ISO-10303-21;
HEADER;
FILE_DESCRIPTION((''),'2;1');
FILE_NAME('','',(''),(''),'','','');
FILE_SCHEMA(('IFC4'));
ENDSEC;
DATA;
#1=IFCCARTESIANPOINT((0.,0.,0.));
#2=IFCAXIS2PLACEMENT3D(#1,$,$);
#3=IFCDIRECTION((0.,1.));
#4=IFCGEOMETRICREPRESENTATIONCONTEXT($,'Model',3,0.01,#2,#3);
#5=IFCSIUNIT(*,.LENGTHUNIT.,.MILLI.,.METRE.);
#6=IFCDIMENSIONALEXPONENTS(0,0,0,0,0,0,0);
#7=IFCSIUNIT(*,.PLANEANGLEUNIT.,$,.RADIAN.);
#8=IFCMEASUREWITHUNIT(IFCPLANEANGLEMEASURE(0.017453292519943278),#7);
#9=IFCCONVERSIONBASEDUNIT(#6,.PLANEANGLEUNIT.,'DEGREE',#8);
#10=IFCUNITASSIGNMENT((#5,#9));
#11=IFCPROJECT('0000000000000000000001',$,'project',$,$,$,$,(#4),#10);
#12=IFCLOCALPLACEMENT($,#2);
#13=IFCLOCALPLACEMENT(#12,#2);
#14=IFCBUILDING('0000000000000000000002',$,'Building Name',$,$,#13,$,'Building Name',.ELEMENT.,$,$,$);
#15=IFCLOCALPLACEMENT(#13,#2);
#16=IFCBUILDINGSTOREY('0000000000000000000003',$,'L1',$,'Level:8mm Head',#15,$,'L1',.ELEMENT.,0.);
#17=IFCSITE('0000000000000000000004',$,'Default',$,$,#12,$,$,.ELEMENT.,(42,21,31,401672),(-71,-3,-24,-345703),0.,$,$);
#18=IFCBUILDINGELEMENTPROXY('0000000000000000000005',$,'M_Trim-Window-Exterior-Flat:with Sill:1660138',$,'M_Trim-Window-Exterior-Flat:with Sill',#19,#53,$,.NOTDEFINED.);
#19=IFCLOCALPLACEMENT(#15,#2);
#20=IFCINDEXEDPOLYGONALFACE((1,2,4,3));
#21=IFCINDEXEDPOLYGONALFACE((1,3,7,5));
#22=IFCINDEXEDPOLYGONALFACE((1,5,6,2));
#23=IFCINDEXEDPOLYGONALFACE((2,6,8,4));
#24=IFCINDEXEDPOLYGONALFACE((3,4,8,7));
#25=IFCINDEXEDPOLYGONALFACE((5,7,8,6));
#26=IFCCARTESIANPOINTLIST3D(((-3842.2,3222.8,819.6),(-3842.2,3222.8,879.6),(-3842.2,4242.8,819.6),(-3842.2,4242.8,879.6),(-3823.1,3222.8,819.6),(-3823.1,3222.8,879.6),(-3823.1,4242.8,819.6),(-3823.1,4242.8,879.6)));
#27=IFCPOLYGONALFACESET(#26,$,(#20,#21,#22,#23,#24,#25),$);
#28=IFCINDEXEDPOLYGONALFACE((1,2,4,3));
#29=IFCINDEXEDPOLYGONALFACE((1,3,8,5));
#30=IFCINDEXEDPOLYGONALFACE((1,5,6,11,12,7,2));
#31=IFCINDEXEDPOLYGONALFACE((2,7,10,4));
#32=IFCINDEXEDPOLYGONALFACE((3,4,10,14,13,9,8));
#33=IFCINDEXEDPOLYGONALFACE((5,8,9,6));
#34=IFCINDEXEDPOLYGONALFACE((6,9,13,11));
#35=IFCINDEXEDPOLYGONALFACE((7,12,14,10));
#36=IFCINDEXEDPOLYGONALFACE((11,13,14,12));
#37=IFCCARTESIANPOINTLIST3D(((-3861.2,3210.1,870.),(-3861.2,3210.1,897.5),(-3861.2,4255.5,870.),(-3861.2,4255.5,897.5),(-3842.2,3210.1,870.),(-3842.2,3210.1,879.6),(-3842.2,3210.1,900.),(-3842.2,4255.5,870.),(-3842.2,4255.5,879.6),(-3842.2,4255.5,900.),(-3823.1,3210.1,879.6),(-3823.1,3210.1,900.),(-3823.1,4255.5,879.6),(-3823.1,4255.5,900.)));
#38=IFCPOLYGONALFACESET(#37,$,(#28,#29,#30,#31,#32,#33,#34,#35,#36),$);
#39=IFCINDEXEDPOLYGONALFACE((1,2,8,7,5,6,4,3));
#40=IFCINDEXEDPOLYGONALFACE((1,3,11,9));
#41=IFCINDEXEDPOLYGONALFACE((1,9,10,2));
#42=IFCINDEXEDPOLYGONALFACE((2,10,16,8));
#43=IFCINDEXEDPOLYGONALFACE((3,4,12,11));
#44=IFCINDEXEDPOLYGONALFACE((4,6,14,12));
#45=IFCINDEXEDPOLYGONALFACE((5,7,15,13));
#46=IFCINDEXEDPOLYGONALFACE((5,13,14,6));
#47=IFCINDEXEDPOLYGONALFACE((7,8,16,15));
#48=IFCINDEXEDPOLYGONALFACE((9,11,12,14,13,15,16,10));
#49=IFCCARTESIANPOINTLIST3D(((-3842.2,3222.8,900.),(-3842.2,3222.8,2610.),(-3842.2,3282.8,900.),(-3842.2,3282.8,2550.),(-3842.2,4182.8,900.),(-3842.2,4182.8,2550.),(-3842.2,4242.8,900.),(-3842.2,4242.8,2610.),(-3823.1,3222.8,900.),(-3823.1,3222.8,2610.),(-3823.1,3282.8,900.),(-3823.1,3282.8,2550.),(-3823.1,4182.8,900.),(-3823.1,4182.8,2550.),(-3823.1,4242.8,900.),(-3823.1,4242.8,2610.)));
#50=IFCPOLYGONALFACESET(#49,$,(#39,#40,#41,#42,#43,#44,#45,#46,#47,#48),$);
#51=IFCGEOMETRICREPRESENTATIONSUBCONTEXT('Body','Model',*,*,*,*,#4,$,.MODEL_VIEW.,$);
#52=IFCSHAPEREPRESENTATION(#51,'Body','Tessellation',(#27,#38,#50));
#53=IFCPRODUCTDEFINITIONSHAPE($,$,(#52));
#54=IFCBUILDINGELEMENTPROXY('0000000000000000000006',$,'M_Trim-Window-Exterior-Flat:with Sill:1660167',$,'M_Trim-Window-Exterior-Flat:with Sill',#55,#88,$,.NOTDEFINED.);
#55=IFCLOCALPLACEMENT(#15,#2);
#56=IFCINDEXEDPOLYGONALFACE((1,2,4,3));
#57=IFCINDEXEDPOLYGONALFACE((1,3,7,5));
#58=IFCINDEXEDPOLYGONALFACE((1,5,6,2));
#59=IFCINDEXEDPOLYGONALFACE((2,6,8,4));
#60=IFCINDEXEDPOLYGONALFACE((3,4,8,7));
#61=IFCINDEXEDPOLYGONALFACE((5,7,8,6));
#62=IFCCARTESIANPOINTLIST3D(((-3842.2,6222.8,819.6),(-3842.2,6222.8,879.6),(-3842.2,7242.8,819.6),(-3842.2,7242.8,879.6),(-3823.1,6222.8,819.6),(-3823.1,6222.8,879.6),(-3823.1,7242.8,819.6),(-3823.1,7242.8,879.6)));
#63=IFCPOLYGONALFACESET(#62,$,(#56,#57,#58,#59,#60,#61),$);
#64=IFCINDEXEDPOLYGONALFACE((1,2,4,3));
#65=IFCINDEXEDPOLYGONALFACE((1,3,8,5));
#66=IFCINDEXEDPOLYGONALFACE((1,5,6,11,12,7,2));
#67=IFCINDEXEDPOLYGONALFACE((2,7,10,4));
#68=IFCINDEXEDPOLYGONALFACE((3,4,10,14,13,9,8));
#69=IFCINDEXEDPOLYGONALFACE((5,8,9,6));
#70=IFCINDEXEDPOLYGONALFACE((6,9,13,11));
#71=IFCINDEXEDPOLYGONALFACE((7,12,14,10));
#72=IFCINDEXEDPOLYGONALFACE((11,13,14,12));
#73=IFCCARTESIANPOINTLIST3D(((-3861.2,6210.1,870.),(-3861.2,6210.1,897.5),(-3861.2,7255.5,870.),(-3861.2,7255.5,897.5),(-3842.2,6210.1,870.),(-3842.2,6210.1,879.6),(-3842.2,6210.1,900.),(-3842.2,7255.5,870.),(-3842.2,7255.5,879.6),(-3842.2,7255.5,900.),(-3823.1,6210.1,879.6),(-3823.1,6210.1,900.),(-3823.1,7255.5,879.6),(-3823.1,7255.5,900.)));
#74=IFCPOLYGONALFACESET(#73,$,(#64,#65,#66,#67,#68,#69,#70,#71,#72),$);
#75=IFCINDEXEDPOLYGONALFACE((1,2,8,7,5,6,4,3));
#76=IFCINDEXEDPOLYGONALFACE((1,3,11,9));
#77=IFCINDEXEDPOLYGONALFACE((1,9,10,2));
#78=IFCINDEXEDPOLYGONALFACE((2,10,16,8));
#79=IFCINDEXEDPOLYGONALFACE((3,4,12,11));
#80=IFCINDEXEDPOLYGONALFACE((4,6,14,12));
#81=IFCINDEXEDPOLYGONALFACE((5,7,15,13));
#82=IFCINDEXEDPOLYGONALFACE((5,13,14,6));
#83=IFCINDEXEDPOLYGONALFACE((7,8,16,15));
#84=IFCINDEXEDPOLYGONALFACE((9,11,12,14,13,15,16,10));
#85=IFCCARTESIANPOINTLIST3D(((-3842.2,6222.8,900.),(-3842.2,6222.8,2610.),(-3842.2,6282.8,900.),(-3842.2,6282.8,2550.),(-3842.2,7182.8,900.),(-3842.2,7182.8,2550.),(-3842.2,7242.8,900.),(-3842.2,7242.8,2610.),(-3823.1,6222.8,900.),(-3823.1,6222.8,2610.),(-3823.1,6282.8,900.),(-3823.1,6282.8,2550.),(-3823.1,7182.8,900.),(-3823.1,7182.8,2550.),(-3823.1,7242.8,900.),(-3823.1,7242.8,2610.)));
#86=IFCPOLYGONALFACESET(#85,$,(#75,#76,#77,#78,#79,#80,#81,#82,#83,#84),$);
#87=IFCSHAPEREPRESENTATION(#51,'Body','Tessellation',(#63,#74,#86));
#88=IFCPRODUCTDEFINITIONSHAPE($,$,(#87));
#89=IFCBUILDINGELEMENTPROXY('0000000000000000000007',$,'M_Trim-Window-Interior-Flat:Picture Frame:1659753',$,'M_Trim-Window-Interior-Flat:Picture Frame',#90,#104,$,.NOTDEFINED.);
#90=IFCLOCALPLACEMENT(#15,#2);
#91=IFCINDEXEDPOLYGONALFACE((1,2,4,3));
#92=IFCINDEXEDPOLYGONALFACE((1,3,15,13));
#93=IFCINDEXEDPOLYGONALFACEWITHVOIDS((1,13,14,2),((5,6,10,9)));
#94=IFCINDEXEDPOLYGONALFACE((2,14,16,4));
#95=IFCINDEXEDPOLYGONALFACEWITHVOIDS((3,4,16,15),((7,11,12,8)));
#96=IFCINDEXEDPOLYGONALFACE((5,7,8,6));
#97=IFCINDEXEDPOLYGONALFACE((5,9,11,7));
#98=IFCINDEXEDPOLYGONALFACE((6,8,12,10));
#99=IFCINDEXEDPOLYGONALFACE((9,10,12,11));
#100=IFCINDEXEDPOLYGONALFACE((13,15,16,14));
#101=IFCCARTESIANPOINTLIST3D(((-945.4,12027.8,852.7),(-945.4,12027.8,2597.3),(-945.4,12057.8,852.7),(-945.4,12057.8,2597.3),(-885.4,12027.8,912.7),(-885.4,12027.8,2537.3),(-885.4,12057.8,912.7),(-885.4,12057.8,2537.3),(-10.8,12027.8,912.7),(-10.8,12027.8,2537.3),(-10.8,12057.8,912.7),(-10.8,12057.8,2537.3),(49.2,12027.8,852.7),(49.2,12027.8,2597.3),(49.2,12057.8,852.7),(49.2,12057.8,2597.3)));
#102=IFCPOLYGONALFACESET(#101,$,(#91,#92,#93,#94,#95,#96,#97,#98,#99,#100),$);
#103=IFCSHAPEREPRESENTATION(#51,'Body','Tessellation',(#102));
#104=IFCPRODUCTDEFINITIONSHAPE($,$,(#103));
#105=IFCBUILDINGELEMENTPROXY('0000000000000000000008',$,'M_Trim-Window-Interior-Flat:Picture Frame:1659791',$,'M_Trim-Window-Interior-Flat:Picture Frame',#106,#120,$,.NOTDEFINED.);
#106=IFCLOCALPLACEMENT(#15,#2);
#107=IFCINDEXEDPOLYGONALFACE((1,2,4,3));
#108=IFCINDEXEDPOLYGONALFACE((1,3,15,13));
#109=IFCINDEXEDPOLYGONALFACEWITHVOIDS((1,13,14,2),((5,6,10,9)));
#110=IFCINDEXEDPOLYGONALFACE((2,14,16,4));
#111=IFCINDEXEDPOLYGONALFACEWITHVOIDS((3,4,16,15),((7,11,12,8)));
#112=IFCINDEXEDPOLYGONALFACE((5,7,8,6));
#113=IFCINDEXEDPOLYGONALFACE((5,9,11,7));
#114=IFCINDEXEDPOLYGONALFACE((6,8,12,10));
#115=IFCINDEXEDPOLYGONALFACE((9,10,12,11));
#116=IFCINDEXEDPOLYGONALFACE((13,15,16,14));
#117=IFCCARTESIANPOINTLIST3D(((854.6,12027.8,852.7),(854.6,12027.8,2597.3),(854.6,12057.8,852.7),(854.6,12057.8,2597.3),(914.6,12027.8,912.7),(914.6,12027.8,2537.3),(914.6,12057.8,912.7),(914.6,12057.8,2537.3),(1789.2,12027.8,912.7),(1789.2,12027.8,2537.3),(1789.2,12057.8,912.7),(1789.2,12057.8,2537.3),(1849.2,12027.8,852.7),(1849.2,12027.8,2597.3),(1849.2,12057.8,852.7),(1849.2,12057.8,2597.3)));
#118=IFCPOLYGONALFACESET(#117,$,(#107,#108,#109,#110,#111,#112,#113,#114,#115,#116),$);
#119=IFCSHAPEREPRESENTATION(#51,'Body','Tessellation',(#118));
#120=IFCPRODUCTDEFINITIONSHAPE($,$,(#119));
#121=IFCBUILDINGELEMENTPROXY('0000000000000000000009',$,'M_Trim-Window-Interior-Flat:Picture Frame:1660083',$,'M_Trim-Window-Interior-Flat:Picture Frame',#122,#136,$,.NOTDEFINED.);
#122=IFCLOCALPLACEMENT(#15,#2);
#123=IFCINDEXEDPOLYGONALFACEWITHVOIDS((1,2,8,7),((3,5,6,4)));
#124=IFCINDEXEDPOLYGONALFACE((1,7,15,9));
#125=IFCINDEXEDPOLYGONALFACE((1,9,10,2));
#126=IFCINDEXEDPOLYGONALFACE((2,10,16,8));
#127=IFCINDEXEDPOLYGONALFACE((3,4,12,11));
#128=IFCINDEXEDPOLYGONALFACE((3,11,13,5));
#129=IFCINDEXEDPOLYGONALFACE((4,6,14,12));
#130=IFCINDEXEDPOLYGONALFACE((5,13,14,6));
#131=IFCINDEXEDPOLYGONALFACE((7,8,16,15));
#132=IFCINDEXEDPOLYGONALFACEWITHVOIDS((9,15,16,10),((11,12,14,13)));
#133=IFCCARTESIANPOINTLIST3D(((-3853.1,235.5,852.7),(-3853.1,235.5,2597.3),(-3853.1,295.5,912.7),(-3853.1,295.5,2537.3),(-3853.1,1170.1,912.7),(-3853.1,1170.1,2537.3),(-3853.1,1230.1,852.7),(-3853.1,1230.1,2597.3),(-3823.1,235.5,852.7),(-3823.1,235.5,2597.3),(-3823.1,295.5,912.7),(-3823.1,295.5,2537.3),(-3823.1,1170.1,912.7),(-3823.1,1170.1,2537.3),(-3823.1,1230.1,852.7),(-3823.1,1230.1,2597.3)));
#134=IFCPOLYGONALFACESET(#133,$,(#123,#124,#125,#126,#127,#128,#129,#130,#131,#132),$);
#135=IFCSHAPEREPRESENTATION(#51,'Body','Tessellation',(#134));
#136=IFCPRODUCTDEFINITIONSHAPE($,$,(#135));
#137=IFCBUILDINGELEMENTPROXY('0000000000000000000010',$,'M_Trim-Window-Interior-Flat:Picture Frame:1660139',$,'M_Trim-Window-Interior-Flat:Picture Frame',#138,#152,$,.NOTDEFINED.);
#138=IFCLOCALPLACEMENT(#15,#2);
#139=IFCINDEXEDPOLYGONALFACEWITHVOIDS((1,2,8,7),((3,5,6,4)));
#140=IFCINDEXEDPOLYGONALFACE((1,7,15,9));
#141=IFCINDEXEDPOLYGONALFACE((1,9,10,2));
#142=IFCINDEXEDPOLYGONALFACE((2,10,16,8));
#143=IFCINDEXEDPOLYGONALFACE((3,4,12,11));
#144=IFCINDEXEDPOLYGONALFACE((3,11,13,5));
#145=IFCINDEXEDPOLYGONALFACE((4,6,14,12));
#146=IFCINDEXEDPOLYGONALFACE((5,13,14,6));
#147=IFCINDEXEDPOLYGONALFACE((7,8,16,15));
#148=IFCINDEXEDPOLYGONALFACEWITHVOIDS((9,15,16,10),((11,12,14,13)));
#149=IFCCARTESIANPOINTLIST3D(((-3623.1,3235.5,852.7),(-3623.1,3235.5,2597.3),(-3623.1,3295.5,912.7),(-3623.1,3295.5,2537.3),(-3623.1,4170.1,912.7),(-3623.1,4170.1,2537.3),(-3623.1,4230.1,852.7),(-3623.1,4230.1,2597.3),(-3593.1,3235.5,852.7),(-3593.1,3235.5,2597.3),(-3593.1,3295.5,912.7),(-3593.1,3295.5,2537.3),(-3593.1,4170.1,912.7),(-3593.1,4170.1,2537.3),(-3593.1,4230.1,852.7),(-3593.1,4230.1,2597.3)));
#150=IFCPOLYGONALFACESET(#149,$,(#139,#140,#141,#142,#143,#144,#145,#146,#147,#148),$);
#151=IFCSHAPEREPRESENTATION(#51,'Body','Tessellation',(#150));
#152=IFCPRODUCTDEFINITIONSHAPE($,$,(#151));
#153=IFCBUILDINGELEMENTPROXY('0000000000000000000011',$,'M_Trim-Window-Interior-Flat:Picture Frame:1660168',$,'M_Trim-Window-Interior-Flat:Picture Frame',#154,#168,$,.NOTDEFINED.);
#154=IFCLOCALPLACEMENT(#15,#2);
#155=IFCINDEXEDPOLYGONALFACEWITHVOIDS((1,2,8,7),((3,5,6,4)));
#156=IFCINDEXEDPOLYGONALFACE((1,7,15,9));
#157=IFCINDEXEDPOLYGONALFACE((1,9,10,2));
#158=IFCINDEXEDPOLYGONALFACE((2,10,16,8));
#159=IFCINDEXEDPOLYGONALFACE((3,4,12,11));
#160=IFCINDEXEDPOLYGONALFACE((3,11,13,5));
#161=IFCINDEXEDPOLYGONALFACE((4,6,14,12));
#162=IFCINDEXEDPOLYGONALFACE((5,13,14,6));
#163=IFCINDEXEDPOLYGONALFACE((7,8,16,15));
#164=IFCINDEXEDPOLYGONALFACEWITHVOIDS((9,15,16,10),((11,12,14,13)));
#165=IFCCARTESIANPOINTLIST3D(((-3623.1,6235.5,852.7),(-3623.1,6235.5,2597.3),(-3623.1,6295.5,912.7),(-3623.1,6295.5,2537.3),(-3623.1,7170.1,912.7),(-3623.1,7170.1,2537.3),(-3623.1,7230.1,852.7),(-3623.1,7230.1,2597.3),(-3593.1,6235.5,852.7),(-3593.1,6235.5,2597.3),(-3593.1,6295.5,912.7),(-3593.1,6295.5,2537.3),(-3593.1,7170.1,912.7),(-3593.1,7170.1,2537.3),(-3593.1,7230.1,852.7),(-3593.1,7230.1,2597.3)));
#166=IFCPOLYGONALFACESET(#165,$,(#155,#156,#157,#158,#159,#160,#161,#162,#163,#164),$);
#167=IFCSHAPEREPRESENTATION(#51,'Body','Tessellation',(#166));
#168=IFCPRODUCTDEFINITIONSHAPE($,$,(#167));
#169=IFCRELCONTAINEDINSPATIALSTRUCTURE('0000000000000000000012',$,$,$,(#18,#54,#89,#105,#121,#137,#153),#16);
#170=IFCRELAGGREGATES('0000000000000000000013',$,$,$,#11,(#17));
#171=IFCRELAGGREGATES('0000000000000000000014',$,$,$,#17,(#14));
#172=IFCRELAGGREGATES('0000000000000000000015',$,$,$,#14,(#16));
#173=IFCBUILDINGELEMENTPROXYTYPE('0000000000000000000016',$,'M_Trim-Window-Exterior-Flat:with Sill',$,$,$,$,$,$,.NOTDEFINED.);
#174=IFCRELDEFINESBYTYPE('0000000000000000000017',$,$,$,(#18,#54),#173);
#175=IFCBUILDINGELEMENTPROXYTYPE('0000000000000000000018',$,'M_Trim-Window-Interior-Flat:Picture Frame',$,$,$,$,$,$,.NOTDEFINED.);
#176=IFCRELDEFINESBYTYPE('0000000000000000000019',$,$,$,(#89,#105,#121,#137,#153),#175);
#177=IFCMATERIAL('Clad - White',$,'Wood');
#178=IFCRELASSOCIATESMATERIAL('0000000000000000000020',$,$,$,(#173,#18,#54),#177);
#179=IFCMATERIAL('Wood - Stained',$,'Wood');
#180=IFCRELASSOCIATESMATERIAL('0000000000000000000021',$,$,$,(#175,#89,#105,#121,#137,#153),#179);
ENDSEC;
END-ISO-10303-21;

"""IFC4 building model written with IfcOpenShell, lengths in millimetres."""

from ifc_helpers import new_model, entity, si_unit, converted_unit, direction, frame, origin, place, context, subcontext, project, spatial, indexed_curve, outline, extrude, source, transform, mapped, material, type_object, type_shapes, element, save


model = new_model("IFC4")

# Units and contexts
model_context = context("Model", 3, precision=0.01, world=origin(), true_north=direction((0.0, 1.0)))
body_context = subcontext(model_context, "Body", "Model", "MODEL_VIEW")
ifc_project = project(units=[si_unit("LENGTHUNIT", "METRE", prefix="MILLI"), converted_unit("PLANEANGLEUNIT", "DEGREE", entity("IfcPlaneAngleMeasure", 0.017453292519943278), si_unit("PLANEANGLEUNIT", "RADIAN"), dimensions=[0, 0, 0, 0, 0, 0, 0])], contexts=[model_context])

# Site, building, storey
site_placement = place(None, origin())
site = spatial("IfcSite", under=ifc_project, at=site_placement, Name="Default", CompositionType="ELEMENT", RefLatitude=(42, 21, 31, 401672), RefLongitude=(-71, -3, -24, -345703), RefElevation=0.0)
building_placement = place(site_placement, origin())
building = spatial("IfcBuilding", under=site, at=building_placement, Name="Building Name", LongName="Building Name", CompositionType="ELEMENT")
storey_placement = place(building_placement, origin())
storey = spatial("IfcBuildingStorey", under=building, at=storey_placement, Name="L1", ObjectType="Level:8mm Head", LongName="L1", CompositionType="ELEMENT", Elevation=0.0)

# Building element proxies
ifc_material_1 = material(Name="Clad - White", Category="Wood")
ifc_material_2 = material(Name="Wood - Stained", Category="Wood")
building_element_proxy_type_1 = type_object("IfcBuildingElementProxyType", Name="M_Trim-Window-Exterior-Flat:with Sill", PredefinedType="NOTDEFINED", material=ifc_material_1)
shared_shape_1 = source(origin(), body_context, "Body", "SweptSolid", [
    extrude(outline(indexed_curve([(-510.0, -30.0), (510.0, -30.0), (510.0, 30.0), (-510.0, 30.0), (-510.0, -30.0)], self_intersect=False)), frame((0.0, -1700.4, 0.0), z_axis=(0.0, 0.0, 1.0), x_axis=(-1.0, 0.0, 0.0)), (0.0, 0.0, 1.0), 19.0),
    extrude(outline(indexed_curve([(-19.0, -15.2), (0.0, -15.2), (0.0, -5.7), (19.0, -5.7), (19.0, 14.8), (0.0, 14.8), (-19.0, 12.3), (-19.0, -15.2)], self_intersect=False)), frame((-522.7, -1664.8, 19.0), z_axis=(1.0, 0.0, 0.0), x_axis=(0.0, 0.0, -1.0)), (0.0, 0.0, 1.0), 1045.4),
    extrude(outline(indexed_curve([(-870.0, -510.0), (840.0, -510.0), (840.0, -450.0), (-810.0, -450.0), (-810.0, 450.0), (840.0, 450.0), (840.0, 510.0), (-870.0, 510.0), (-870.0, -510.0)], self_intersect=False)), frame((0.0, -810.0, 0.0), z_axis=(0.0, 0.0, 1.0), x_axis=(0.0, -1.0, 0.0)), (0.0, 0.0, 1.0), 19.0),
])
type_shapes(building_element_proxy_type_1, [shared_shape_1])
for number, where, z_axis, x_axis, name in (
    (1, (-3823.1, 3732.8, 2550.0), (-1.0, 0.0, 0.0), (0.0, -1.0, 0.0), "M_Trim-Window-Exterior-Flat:with Sill:1660138"),
    (2, (-3823.1, 6732.8, 2550.0), (-1.0, 0.0, 0.0), (0.0, -1.0, 0.0), "M_Trim-Window-Exterior-Flat:with Sill:1660167"),
):
    element("IfcBuildingElementProxy", number, at=place(storey_placement, frame(where, z_axis=z_axis, x_axis=x_axis)), inside=storey, type_object=building_element_proxy_type_1, material=ifc_material_1, Name=name, ObjectType="M_Trim-Window-Exterior-Flat:with Sill", PredefinedType="NOTDEFINED", context=body_context, shape_type="MappedRepresentation", body=[
        mapped(shared_shape_1, transform((0.0, 0.0, 0.0), scale=1.0)),
    ])
building_element_proxy_type_2 = type_object("IfcBuildingElementProxyType", Name="M_Trim-Window-Interior-Flat:Picture Frame", PredefinedType="NOTDEFINED", material=ifc_material_2)
shared_shape_2 = source(origin(), body_context, "Body", "SweptSolid", [
    extrude(outline(indexed_curve([(-497.3, -872.3), (497.3, -872.3), (497.3, 872.3), (-497.3, 872.3), (-497.3, -872.3)], self_intersect=False), holes=[indexed_curve([(-437.3, -812.3), (-437.3, 812.3), (437.3, 812.3), (437.3, -812.3), (-437.3, -812.3)], self_intersect=False)]), frame((0.0, -825.0, 0.0), z_axis=(0.0, 0.0, 1.0), x_axis=(-1.0, 0.0, 0.0)), (0.0, 0.0, 1.0), 30.0),
])
type_shapes(building_element_proxy_type_2, [shared_shape_2])
for number, where, z_axis, x_axis, name in (
    (3, (-448.1, 12057.8, 2550.0), (0.0, -1.0, 0.0), (1.0, 0.0, 0.0), "M_Trim-Window-Interior-Flat:Picture Frame:1659753"),
    (4, (1351.9, 12057.8, 2550.0), (0.0, -1.0, 0.0), (1.0, 0.0, 0.0), "M_Trim-Window-Interior-Flat:Picture Frame:1659791"),
    (5, (-3823.1, 732.8, 2550.0), (-1.0, 0.0, 0.0), (0.0, -1.0, 0.0), "M_Trim-Window-Interior-Flat:Picture Frame:1660083"),
    (6, (-3623.1, 3732.8, 2550.0), (1.0, 0.0, 0.0), (0.0, 1.0, 0.0), "M_Trim-Window-Interior-Flat:Picture Frame:1660139"),
    (7, (-3623.1, 6732.8, 2550.0), (1.0, 0.0, 0.0), (0.0, 1.0, 0.0), "M_Trim-Window-Interior-Flat:Picture Frame:1660168"),
):
    element("IfcBuildingElementProxy", number, at=place(storey_placement, frame(where, z_axis=z_axis, x_axis=x_axis)), inside=storey, type_object=building_element_proxy_type_2, material=ifc_material_2, Name=name, ObjectType="M_Trim-Window-Interior-Flat:Picture Frame", PredefinedType="NOTDEFINED", context=body_context, shape_type="MappedRepresentation", body=[
        mapped(shared_shape_2, transform((0.0, 0.0, 0.0), scale=1.0)),
    ])

save(model, "model.ifc")
